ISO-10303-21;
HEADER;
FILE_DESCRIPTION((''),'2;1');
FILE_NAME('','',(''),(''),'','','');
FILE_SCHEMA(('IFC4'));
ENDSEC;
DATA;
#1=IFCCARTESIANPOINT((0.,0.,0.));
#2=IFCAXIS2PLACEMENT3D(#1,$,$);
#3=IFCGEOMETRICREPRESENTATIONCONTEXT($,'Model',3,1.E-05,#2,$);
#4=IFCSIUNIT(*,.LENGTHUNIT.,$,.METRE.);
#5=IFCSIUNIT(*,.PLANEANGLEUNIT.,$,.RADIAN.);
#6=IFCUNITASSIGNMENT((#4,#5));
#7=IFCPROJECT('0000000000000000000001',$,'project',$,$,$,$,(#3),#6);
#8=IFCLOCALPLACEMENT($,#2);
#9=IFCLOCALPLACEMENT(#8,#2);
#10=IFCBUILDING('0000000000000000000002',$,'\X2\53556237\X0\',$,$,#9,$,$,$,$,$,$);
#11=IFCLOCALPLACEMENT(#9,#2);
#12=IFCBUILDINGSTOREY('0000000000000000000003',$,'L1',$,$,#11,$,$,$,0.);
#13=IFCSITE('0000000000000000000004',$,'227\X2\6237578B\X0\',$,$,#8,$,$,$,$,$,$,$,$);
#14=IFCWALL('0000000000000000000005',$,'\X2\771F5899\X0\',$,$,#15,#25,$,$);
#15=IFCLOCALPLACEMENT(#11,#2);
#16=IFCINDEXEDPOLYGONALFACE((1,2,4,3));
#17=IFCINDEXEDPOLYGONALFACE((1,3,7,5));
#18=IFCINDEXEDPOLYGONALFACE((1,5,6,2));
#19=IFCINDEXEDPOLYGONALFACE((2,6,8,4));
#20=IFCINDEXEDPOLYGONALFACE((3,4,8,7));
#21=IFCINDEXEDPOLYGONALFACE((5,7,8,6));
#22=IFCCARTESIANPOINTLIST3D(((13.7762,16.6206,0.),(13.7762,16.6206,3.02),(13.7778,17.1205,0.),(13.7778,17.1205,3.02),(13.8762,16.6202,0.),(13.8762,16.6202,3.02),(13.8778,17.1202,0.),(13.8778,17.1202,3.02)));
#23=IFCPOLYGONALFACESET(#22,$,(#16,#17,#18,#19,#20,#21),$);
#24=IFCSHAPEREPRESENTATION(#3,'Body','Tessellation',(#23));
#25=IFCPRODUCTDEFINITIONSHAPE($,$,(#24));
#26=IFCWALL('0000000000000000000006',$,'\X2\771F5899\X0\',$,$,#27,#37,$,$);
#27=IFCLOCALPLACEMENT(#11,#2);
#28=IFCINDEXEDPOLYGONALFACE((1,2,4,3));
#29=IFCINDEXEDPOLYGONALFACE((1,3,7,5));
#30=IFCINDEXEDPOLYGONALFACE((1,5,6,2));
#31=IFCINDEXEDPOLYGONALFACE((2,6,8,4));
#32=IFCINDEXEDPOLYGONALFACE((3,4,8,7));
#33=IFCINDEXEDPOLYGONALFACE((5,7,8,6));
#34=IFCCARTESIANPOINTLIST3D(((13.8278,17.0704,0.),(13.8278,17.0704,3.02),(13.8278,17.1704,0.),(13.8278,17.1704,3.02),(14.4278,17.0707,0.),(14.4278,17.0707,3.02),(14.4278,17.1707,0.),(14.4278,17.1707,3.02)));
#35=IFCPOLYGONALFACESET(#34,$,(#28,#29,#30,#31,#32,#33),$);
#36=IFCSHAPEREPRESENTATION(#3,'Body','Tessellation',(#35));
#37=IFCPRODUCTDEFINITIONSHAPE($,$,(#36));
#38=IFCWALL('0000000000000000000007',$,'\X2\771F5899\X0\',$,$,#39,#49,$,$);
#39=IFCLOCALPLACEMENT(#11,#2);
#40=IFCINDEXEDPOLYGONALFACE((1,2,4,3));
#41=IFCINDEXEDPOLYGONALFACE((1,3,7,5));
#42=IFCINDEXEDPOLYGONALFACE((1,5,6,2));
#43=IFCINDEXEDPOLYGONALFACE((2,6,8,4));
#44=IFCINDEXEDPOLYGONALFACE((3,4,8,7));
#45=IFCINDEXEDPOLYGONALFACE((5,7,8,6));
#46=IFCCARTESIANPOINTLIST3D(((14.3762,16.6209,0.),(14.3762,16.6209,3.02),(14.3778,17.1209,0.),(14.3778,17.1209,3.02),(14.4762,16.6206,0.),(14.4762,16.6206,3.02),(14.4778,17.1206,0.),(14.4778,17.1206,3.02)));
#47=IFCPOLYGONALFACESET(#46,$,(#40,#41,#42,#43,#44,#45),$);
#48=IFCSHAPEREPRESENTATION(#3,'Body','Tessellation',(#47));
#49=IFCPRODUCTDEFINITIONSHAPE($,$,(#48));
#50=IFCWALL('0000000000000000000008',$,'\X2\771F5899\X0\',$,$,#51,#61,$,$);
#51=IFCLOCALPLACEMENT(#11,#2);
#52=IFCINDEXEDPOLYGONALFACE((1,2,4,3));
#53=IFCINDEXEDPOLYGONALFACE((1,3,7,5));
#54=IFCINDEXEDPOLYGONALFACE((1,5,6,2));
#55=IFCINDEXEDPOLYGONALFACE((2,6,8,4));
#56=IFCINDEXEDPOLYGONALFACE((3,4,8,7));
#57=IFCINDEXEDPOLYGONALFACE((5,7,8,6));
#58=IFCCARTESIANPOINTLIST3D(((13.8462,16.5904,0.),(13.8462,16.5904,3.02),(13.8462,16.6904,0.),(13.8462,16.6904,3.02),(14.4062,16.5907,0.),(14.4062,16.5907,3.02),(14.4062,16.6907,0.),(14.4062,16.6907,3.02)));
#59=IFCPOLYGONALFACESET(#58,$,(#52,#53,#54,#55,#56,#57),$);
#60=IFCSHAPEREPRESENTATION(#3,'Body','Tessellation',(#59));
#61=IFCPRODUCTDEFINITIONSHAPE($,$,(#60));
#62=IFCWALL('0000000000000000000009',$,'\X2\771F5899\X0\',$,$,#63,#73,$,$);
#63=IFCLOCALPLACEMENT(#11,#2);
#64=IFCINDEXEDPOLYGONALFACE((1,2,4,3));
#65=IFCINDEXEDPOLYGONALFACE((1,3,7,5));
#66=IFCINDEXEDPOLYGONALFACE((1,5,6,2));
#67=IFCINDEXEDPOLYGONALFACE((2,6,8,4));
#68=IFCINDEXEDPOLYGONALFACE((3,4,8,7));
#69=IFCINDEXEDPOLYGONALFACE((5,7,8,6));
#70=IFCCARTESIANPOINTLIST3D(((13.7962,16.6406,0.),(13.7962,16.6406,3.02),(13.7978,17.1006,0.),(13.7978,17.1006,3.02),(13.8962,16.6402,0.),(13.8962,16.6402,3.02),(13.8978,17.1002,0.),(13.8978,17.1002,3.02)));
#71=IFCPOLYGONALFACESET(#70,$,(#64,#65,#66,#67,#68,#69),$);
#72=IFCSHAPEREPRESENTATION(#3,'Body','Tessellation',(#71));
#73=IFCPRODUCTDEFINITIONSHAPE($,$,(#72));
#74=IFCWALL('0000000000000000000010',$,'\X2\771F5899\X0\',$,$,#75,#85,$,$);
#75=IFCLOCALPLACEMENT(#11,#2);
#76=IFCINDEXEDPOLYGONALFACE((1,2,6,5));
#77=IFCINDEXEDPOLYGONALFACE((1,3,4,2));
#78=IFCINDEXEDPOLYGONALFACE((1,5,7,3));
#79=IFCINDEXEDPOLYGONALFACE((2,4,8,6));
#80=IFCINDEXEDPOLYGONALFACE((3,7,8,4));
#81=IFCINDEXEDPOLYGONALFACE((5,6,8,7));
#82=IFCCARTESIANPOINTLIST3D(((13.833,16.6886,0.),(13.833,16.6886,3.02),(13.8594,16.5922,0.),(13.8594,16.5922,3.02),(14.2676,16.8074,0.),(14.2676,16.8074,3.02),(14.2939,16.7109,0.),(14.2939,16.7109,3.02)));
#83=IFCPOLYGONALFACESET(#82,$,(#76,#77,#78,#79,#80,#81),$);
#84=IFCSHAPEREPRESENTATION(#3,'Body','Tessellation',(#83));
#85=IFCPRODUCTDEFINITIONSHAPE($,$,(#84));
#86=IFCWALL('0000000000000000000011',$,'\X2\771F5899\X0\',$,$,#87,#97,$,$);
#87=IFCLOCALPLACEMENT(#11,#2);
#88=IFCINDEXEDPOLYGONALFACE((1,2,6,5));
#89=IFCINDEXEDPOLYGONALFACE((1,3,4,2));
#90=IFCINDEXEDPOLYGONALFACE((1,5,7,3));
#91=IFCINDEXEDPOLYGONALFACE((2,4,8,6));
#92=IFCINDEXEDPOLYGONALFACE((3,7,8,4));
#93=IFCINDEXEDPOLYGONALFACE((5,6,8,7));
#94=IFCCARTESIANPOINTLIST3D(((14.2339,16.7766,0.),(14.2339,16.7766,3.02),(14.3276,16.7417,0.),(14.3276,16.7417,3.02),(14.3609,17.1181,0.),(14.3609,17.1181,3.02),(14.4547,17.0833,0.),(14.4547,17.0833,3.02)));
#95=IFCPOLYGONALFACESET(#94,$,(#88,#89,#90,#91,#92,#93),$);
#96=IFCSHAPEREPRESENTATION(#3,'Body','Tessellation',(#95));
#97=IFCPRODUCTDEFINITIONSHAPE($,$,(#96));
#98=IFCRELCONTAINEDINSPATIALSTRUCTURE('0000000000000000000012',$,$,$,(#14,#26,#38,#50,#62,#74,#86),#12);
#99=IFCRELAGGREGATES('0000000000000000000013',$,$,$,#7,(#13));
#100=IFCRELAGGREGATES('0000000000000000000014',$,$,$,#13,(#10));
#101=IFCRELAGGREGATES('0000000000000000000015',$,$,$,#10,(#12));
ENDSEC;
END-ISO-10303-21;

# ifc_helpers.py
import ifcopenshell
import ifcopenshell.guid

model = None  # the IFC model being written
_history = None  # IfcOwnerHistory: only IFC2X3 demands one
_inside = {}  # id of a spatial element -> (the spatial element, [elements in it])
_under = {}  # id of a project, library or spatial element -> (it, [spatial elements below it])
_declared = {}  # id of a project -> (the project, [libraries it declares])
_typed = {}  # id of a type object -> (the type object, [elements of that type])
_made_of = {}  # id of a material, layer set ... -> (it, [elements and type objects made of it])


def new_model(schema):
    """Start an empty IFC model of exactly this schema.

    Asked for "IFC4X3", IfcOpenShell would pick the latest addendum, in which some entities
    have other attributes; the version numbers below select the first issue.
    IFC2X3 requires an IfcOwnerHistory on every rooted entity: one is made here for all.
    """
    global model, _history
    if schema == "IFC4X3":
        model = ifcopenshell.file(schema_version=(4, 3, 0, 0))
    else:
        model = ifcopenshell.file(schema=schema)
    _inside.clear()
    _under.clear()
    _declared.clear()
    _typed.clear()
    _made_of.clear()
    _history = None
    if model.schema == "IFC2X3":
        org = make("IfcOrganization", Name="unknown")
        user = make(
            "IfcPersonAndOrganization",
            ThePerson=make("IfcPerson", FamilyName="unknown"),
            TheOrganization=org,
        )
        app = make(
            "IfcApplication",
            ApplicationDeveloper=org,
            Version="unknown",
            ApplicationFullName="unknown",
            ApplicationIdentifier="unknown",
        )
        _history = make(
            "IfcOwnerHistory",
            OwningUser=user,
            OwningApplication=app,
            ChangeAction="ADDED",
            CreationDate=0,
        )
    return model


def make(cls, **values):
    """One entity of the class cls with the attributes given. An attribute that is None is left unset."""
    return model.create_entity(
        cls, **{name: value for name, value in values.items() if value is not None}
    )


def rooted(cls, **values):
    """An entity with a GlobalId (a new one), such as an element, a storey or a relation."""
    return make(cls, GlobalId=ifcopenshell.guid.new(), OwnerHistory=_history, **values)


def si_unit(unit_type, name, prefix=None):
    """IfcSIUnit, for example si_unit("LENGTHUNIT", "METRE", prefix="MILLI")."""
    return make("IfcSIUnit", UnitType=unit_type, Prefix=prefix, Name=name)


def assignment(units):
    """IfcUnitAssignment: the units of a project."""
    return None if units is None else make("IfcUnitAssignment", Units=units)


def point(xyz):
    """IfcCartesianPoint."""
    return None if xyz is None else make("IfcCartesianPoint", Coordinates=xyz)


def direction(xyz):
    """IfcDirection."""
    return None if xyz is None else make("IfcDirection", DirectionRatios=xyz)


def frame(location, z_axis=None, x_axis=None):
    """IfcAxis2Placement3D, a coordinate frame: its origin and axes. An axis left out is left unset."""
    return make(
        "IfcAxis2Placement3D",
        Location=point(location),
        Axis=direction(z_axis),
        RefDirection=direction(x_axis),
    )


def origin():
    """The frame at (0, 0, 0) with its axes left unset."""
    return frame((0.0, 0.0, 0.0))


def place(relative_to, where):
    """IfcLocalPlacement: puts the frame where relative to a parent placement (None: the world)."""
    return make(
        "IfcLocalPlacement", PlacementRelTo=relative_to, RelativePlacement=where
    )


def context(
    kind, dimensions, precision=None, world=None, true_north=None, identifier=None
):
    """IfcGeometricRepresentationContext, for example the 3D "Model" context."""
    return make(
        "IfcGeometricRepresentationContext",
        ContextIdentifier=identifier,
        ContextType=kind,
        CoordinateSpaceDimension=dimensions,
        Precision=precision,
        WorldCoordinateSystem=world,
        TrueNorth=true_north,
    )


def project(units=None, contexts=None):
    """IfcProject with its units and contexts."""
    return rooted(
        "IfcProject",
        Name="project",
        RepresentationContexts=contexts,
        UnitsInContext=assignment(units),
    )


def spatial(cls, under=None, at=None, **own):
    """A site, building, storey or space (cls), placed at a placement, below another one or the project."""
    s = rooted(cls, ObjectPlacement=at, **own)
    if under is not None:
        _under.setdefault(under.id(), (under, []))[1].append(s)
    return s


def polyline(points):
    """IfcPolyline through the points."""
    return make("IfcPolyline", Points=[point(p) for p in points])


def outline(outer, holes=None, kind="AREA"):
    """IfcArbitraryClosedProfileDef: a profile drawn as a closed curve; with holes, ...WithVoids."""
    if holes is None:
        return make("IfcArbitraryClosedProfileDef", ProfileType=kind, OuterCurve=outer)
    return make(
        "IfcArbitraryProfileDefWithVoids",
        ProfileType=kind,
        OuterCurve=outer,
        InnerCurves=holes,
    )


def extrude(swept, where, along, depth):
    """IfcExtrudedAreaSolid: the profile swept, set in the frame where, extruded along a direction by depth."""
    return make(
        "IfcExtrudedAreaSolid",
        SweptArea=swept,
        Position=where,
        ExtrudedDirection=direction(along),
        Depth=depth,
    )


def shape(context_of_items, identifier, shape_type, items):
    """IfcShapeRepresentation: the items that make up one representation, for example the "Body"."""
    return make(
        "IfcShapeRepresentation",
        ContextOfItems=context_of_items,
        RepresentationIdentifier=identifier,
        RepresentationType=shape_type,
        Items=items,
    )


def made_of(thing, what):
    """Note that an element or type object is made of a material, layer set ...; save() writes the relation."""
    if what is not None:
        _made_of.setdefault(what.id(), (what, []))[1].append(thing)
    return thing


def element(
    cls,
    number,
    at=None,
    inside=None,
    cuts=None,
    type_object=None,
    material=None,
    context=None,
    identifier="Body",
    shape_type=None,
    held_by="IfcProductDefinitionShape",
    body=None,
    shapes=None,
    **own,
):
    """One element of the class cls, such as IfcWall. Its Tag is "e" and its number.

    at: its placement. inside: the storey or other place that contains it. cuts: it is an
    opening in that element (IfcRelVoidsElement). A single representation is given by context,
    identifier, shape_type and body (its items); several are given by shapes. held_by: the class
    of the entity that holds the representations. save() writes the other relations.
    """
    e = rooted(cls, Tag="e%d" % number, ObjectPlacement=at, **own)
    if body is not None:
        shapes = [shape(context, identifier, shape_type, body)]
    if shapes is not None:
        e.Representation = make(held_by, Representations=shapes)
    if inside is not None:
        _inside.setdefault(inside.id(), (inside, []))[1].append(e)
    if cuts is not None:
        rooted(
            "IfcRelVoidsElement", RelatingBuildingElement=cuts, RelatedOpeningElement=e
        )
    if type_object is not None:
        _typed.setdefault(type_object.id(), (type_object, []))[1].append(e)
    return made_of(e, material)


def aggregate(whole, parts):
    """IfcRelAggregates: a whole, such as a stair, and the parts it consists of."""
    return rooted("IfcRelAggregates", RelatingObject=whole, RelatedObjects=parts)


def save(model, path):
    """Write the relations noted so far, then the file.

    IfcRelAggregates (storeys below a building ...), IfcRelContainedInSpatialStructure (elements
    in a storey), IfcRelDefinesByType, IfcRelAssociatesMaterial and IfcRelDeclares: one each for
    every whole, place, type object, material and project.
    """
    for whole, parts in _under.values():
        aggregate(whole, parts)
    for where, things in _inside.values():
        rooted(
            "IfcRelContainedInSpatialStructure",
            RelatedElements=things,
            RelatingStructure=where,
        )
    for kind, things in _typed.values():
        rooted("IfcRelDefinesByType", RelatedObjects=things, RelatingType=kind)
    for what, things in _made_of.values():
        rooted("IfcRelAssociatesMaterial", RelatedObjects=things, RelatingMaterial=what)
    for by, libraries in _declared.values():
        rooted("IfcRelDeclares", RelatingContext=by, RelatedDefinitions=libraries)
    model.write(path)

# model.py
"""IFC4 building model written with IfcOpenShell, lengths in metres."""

from ifc_helpers import new_model, si_unit, origin, place, context, project, spatial, polyline, outline, extrude, element, save


model = new_model("IFC4")

# Units and contexts
model_context = context("Model", 3, precision=1e-05, world=origin())
ifc_project = project(units=[si_unit("LENGTHUNIT", "METRE"), si_unit("PLANEANGLEUNIT", "RADIAN")], contexts=[model_context])

# Site, building, storey
site_placement = place(None, origin())
site = spatial("IfcSite", under=ifc_project, at=site_placement, Name="227户型")
building_placement = place(site_placement, origin())
building = spatial("IfcBuilding", under=site, at=building_placement, Name="单户")
storey_placement = place(building_placement, origin())
storey = spatial("IfcBuildingStorey", under=building, at=storey_placement, Name="L1", Elevation=0.0)

# Walls
wall_1_placement = place(storey_placement, origin())
element("IfcWall", 1, at=wall_1_placement, inside=storey, Name="真墙", context=model_context, shape_type="SweptSolid", body=[
    extrude(outline(polyline([(13.7762, 16.6206), (13.7778, 17.1205), (13.8778, 17.1202), (13.8762, 16.6202), (13.7762, 16.6206)])), origin(), (0.0, 0.0, 1.0), 3.02),
])
wall_2_placement = place(storey_placement, origin())
element("IfcWall", 2, at=wall_2_placement, inside=storey, Name="真墙", context=model_context, shape_type="SweptSolid", body=[
    extrude(outline(polyline([(13.8278, 17.1704), (14.4278, 17.1707), (14.4278, 17.0707), (13.8278, 17.0704), (13.8278, 17.1704)])), origin(), (0.0, 0.0, 1.0), 3.02),
])
wall_3_placement = place(storey_placement, origin())
element("IfcWall", 3, at=wall_3_placement, inside=storey, Name="真墙", context=model_context, shape_type="SweptSolid", body=[
    extrude(outline(polyline([(14.4778, 17.1206), (14.4762, 16.6206), (14.3762, 16.6209), (14.3778, 17.1209), (14.4778, 17.1206)])), origin(), (0.0, 0.0, 1.0), 3.02),
])
wall_4_placement = place(storey_placement, origin())
element("IfcWall", 4, at=wall_4_placement, inside=storey, Name="真墙", context=model_context, shape_type="SweptSolid", body=[
    extrude(outline(polyline([(14.4062, 16.5907), (13.8462, 16.5904), (13.8462, 16.6904), (14.4062, 16.6907), (14.4062, 16.5907)])), origin(), (0.0, 0.0, 1.0), 3.02),
])
wall_5_placement = place(storey_placement, origin())
element("IfcWall", 5, at=wall_5_placement, inside=storey, Name="真墙", context=model_context, shape_type="SweptSolid", body=[
    extrude(outline(polyline([(13.7962, 16.6406), (13.7978, 17.1006), (13.8978, 17.1002), (13.8962, 16.6402), (13.7962, 16.6406)])), origin(), (0.0, 0.0, 1.0), 3.02),
])

# Walls
wall_6_placement = place(storey_placement, origin())
element("IfcWall", 6, at=wall_6_placement, inside=storey, Name="真墙", context=model_context, shape_type="SweptSolid", body=[
    extrude(outline(polyline([(13.833, 16.6886), (14.2676, 16.8074), (14.2939, 16.7109), (13.8594, 16.5922), (13.833, 16.6886)])), origin(), (0.0, 0.0, 1.0), 3.02),
])
wall_7_placement = place(storey_placement, origin())
element("IfcWall", 7, at=wall_7_placement, inside=storey, Name="真墙", context=model_context, shape_type="SweptSolid", body=[
    extrude(outline(polyline([(14.2339, 16.7766), (14.3609, 17.1181), (14.4547, 17.0833), (14.3276, 16.7417), (14.2339, 16.7766)])), origin(), (0.0, 0.0, 1.0), 3.02),
])

save(model, "model.ifc")
